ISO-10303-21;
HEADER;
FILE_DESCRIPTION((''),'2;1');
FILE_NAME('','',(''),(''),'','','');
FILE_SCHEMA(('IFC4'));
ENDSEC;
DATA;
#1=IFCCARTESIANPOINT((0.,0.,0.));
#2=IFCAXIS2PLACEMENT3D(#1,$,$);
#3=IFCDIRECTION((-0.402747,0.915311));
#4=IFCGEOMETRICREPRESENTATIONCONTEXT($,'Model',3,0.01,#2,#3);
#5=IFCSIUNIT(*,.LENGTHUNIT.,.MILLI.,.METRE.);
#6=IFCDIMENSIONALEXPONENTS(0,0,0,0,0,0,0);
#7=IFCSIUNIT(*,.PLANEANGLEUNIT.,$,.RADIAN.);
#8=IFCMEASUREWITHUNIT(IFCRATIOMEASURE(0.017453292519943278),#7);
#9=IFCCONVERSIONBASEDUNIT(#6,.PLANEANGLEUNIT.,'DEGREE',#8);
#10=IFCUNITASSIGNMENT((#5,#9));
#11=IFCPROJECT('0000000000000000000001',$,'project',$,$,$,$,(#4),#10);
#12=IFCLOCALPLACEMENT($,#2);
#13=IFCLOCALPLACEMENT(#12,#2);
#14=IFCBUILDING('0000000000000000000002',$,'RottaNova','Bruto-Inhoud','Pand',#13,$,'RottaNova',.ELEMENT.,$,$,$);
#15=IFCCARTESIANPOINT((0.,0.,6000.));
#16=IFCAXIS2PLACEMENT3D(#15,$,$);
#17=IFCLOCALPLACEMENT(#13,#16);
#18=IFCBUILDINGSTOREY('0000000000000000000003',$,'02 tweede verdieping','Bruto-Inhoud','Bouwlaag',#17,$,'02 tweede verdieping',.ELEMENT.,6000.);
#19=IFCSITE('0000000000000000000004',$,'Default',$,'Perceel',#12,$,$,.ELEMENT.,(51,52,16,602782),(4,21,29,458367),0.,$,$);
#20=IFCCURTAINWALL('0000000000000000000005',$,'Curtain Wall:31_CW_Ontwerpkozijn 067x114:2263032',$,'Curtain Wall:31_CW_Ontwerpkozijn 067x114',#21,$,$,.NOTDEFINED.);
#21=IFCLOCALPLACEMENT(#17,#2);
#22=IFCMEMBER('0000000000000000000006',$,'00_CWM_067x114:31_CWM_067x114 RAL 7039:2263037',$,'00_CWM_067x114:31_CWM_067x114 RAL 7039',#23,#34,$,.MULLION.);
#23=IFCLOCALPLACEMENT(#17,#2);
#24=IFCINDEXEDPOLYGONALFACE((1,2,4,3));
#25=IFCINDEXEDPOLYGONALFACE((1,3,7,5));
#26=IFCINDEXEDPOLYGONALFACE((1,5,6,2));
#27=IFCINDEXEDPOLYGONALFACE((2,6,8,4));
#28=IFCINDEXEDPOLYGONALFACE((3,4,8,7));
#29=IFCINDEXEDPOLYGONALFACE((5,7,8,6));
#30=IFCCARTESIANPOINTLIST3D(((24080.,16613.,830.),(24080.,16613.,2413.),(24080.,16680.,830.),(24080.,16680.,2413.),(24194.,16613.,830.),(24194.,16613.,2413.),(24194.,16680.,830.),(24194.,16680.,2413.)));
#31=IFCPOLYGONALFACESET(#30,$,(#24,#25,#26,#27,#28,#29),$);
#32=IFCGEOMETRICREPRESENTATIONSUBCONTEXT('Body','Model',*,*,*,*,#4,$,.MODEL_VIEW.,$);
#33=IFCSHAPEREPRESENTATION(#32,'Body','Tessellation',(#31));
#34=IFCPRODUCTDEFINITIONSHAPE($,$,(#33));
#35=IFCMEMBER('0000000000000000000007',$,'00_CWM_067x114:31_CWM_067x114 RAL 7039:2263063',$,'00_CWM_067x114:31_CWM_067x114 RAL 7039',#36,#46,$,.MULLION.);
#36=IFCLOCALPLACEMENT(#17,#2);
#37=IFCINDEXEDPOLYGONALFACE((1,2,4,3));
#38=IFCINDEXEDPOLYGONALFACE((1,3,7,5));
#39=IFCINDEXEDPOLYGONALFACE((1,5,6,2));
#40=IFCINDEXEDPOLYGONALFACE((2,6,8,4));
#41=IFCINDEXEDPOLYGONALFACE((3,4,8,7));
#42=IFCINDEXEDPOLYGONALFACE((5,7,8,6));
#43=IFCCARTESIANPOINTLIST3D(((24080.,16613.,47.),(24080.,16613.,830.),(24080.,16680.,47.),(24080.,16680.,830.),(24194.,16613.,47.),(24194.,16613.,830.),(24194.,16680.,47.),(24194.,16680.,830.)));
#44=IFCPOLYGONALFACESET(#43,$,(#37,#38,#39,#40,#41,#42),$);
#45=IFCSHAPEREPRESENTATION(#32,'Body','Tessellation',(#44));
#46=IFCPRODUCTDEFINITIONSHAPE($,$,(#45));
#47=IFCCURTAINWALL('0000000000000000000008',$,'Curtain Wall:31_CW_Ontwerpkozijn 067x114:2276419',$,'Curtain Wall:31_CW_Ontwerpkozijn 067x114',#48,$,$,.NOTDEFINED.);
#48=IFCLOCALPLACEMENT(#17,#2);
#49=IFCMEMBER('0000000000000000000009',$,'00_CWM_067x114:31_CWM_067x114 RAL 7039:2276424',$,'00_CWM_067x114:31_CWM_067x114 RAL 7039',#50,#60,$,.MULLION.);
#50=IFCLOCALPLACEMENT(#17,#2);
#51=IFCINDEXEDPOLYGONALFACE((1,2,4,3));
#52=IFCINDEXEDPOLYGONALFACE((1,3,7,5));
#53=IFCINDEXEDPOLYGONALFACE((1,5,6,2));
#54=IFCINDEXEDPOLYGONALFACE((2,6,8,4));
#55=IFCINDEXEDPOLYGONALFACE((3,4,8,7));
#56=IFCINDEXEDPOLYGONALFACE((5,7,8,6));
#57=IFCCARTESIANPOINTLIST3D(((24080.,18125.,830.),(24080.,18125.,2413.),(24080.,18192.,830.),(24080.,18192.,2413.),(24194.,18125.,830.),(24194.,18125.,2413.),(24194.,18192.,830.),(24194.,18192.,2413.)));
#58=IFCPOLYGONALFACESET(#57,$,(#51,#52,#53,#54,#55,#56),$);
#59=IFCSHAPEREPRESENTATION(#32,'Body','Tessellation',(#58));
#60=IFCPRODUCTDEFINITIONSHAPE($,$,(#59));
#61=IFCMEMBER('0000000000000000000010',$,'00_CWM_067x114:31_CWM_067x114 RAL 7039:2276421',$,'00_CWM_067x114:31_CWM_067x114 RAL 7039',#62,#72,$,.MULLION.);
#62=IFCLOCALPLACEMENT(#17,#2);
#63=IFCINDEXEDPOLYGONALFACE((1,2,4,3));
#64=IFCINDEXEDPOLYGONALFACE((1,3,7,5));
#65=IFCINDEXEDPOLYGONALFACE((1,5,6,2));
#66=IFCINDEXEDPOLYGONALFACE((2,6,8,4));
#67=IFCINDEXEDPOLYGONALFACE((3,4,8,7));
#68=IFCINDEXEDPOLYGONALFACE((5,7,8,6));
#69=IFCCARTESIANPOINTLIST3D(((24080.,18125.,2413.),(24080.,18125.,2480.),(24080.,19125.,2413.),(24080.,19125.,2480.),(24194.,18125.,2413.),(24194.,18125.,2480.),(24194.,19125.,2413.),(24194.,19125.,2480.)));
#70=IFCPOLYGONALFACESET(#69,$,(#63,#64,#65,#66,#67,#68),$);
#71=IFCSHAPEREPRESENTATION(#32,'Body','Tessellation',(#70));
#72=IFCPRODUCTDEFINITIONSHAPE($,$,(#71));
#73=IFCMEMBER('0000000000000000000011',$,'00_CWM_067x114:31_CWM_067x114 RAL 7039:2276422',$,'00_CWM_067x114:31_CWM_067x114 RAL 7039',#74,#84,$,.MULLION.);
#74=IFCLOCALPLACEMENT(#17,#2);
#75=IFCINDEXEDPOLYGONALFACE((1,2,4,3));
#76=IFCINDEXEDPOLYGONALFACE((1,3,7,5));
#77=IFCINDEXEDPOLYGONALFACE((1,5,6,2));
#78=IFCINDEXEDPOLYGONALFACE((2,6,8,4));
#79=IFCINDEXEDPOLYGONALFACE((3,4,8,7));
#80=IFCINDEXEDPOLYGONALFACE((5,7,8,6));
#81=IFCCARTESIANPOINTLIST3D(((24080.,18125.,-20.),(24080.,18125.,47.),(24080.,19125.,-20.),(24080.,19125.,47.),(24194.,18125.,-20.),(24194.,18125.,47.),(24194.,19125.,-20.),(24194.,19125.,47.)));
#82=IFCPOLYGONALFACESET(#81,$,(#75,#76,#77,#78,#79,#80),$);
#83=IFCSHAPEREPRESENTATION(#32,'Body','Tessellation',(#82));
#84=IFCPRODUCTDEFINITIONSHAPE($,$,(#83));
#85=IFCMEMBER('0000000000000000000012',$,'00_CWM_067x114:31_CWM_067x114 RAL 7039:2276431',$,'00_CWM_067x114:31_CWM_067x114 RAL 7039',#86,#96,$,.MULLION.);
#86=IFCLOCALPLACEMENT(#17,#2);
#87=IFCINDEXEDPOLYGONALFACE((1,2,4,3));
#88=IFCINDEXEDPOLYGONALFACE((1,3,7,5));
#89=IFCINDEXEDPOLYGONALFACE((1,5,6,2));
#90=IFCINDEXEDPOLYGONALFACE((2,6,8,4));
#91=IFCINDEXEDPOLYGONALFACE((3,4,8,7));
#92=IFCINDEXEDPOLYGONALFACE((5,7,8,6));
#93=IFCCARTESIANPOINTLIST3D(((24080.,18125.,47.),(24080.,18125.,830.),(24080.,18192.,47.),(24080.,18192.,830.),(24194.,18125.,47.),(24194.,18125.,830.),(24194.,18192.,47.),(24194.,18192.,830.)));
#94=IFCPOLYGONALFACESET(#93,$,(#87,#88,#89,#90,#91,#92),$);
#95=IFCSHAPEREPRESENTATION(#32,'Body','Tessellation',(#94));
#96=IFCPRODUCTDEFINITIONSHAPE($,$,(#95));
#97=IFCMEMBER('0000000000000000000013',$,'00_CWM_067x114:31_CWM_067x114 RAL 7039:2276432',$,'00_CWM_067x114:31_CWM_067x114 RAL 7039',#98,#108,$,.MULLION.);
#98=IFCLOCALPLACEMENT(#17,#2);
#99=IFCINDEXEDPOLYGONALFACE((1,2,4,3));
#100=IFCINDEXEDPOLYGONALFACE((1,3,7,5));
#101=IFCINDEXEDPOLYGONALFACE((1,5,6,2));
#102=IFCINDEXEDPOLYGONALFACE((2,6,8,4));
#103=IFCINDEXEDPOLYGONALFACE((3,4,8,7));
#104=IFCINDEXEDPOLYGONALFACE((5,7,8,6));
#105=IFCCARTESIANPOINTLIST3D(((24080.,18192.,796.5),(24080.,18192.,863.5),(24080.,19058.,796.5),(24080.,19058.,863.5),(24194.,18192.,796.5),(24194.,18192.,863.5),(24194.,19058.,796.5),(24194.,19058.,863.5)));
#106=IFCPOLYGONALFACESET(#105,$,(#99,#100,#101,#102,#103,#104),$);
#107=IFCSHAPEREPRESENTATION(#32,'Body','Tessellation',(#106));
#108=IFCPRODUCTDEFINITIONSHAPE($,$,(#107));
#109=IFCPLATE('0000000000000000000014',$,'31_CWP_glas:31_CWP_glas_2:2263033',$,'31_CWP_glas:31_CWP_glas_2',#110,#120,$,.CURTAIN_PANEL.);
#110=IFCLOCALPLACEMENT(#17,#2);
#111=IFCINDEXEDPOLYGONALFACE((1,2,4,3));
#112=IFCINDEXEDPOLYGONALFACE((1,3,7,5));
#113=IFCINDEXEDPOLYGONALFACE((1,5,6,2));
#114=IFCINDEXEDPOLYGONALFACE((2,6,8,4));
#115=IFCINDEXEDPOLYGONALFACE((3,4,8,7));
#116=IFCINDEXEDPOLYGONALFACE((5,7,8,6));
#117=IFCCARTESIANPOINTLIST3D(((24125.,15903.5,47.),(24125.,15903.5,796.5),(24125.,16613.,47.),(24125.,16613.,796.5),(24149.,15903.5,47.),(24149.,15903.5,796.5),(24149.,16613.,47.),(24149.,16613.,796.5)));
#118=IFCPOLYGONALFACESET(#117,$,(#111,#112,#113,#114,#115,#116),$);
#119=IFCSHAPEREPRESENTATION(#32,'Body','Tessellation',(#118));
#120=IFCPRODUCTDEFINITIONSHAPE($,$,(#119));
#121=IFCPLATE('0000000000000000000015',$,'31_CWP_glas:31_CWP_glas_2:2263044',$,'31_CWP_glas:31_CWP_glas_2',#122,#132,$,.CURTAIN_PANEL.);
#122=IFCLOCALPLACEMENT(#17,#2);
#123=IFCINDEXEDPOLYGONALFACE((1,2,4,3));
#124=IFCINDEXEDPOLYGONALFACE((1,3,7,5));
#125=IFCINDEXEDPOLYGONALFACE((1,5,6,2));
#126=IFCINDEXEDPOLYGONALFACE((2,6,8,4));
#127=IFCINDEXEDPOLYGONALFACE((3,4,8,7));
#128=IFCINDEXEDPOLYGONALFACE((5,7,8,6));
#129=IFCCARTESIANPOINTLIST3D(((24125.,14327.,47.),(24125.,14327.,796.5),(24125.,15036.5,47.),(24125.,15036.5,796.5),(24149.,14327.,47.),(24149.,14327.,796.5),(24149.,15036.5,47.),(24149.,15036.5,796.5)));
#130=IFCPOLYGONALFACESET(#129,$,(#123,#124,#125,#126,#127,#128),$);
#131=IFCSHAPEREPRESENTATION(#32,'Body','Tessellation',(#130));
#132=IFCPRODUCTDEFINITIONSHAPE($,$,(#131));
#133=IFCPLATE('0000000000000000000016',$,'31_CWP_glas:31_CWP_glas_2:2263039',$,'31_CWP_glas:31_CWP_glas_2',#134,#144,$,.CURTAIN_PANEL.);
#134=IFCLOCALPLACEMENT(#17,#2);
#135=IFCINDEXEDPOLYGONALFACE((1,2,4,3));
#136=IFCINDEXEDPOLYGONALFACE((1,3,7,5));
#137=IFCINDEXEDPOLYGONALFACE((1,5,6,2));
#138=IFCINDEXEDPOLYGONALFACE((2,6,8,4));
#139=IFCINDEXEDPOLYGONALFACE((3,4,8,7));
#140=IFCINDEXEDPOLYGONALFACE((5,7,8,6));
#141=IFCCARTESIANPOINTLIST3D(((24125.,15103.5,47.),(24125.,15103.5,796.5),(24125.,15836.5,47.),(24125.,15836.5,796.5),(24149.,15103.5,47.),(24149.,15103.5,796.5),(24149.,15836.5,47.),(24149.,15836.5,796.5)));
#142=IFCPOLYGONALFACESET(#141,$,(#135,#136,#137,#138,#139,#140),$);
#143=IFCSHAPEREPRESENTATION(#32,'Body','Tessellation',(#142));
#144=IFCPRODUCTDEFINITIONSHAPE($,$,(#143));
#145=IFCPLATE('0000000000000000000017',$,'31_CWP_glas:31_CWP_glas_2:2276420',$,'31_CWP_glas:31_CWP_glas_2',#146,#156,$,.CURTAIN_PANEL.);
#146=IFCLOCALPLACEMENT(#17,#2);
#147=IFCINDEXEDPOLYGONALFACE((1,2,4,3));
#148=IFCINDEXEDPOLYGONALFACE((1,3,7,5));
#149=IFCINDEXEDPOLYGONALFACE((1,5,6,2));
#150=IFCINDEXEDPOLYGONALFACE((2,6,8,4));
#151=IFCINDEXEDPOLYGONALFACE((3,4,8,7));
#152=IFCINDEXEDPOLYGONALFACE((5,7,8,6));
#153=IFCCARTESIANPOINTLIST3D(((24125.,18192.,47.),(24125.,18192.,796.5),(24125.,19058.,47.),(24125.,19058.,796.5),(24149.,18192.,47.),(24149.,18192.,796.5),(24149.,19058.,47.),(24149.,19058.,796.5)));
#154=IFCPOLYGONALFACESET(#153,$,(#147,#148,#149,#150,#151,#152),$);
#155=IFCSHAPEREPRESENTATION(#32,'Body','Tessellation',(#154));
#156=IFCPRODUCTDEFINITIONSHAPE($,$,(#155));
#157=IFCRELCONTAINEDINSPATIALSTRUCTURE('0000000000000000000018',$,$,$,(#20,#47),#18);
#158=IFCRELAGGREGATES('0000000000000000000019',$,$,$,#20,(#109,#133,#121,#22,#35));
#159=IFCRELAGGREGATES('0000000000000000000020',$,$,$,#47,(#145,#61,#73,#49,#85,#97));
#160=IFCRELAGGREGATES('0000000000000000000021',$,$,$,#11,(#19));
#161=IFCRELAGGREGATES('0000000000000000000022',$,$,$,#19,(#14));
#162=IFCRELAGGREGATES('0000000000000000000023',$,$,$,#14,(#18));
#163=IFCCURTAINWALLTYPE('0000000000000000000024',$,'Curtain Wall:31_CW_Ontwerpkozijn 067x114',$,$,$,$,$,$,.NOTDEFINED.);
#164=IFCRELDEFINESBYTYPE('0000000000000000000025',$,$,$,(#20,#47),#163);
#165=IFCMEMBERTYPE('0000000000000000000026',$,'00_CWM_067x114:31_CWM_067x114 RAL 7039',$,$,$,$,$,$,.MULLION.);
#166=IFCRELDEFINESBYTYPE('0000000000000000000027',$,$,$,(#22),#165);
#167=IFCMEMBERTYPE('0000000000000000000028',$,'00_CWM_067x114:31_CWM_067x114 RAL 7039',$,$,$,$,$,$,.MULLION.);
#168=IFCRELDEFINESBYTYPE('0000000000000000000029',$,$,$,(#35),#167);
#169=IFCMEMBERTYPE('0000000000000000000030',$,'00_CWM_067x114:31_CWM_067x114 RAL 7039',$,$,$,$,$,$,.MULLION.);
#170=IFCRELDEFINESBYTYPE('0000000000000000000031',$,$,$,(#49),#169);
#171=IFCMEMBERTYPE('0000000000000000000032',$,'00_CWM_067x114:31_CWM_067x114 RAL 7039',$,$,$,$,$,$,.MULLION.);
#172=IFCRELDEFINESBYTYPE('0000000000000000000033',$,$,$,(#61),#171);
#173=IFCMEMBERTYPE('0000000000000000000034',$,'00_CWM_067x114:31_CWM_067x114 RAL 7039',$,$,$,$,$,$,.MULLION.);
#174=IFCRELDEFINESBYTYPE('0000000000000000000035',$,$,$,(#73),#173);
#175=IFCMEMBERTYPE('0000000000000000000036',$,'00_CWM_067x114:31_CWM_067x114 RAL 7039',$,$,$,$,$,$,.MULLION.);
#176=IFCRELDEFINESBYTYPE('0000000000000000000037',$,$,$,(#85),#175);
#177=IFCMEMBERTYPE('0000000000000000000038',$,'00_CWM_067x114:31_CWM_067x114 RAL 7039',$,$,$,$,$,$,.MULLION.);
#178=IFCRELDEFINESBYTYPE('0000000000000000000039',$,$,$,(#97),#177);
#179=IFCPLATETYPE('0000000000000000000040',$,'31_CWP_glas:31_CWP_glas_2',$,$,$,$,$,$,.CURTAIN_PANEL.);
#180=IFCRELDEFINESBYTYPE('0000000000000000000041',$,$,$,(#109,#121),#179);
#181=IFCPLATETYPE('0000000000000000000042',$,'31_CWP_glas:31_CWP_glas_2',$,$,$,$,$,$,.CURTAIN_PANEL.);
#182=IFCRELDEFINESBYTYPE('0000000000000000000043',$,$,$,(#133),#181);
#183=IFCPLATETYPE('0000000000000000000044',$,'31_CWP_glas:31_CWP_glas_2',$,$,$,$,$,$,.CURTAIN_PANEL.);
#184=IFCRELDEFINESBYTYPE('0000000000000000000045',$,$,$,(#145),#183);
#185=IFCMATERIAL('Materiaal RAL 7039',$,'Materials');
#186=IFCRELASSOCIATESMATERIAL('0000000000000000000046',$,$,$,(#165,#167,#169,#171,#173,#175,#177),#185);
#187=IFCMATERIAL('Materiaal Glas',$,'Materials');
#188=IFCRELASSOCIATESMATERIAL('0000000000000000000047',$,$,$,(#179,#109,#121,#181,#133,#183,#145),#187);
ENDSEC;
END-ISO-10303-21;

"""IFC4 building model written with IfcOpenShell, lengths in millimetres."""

from ifc_helpers import new_model, entity, si_unit, converted_unit, direction, frame, frame_2d, origin, origin_2d_with_axis, place, context, subcontext, project, spatial, rectangle, extrude, source, transform, mapped, material, material_profile, profile_set, type_object, type_shapes, element, aggregate, save


model = new_model("IFC4")

# Units and contexts
model_context = context("Model", 3, precision=0.01, world=origin(), true_north=direction((-0.402747, 0.915311)))
body_context = subcontext(model_context, "Body", "Model", "MODEL_VIEW")
ifc_project = project(units=[si_unit("LENGTHUNIT", "METRE", prefix="MILLI"), converted_unit("PLANEANGLEUNIT", "DEGREE", entity("IfcRatioMeasure", 0.017453292519943278), si_unit("PLANEANGLEUNIT", "RADIAN"), dimensions=[0, 0, 0, 0, 0, 0, 0])], contexts=[model_context])

# Site, building, storey
site_placement = place(None, origin())
site = spatial("IfcSite", under=ifc_project, at=site_placement, Name="Default", ObjectType="Perceel", CompositionType="ELEMENT", RefLatitude=(51, 52, 16, 602782), RefLongitude=(4, 21, 29, 458367), RefElevation=0.0)
building_placement = place(site_placement, origin())
building = spatial("IfcBuilding", under=site, at=building_placement, Name="RottaNova", Description="Bruto-Inhoud", ObjectType="Pand", LongName="RottaNova", CompositionType="ELEMENT")
storey_placement = place(building_placement, frame((0.0, 0.0, 6000.0)))
storey = spatial("IfcBuildingStorey", under=building, at=storey_placement, Name="02 tweede verdieping", Description="Bruto-Inhoud", ObjectType="Bouwlaag", LongName="02 tweede verdieping", CompositionType="ELEMENT", Elevation=6000.0)

# Curtain walls, members
curtain_wall_type = type_object("IfcCurtainWallType", Name="Curtain Wall:31_CW_Ontwerpkozijn 067x114", PredefinedType="NOTDEFINED")
curtain_wall_1_placement = place(storey_placement, frame((0.0, 0.0, -6000.0)))
curtain_wall_1 = element("IfcCurtainWall", 1, at=curtain_wall_1_placement, inside=storey, type_object=curtain_wall_type, Name="Curtain Wall:31_CW_Ontwerpkozijn 067x114:2263032", ObjectType="Curtain Wall:31_CW_Ontwerpkozijn 067x114", PredefinedType="NOTDEFINED")
ifc_material_1 = material(Name="Materiaal RAL 7039", Category="Materials")
ifc_material_profile = material_profile(ifc_material_1, rectangle(XDim=114.0, YDim=67.0, at=origin_2d_with_axis()), Name="31_CWM_067x114 RAL 7039")
ifc_profile_set = profile_set([ifc_material_profile], Name="31_CWM_067x114 RAL 7039")
member_type_1 = type_object("IfcMemberType", Name="00_CWM_067x114:31_CWM_067x114 RAL 7039", PredefinedType="MULLION", material=ifc_profile_set)
shared_shape_1 = source(origin(), body_context, "Body", "SweptSolid", [
    extrude(rectangle(XDim=114.0, YDim=67.0, at=frame_2d((0.0, 0.0), x_axis=(1.0, 0.0))), frame((-33.5, -57.0, -1583.0), z_axis=(0.0, 0.0, 1.0), x_axis=(0.0, -1.0, 0.0)), (0.0, 0.0, 1.0), 1583.0),
])
type_shapes(member_type_1, [shared_shape_1])
member_1_placement = place(curtain_wall_1_placement, frame((24080.0, 16680.0, 8413.0), z_axis=(0.0, 0.0, 1.0), x_axis=(0.0, 1.0, 0.0)))
member_1 = element("IfcMember", 2, at=member_1_placement, type_object=member_type_1, Name="00_CWM_067x114:31_CWM_067x114 RAL 7039:2263037", ObjectType="00_CWM_067x114:31_CWM_067x114 RAL 7039", PredefinedType="MULLION", context=body_context, shape_type="MappedRepresentation", body=[
    mapped(shared_shape_1, transform((0.0, 0.0, 0.0), scale=1.0)),
])
member_type_2 = type_object("IfcMemberType", Name="00_CWM_067x114:31_CWM_067x114 RAL 7039", PredefinedType="MULLION", material=ifc_profile_set)
shared_shape_2 = source(origin(), body_context, "Body", "SweptSolid", [
    extrude(rectangle(XDim=114.0, YDim=67.0, at=frame_2d((0.0, 0.0), x_axis=(1.0, 0.0))), frame((-33.5, -57.0, -783.0), z_axis=(0.0, 0.0, 1.0), x_axis=(0.0, -1.0, 0.0)), (0.0, 0.0, 1.0), 783.0),
])
type_shapes(member_type_2, [shared_shape_2])
member_2_placement = place(curtain_wall_1_placement, frame((24080.0, 16680.0, 6830.0), z_axis=(0.0, 0.0, 1.0), x_axis=(0.0, 1.0, 0.0)))
member_2 = element("IfcMember", 3, at=member_2_placement, type_object=member_type_2, Name="00_CWM_067x114:31_CWM_067x114 RAL 7039:2263063", ObjectType="00_CWM_067x114:31_CWM_067x114 RAL 7039", PredefinedType="MULLION", context=body_context, shape_type="MappedRepresentation", body=[
    mapped(shared_shape_2, transform((0.0, 0.0, 0.0), scale=1.0)),
])
curtain_wall_2_placement = place(storey_placement, frame((0.0, 0.0, -6000.0)))
curtain_wall_2 = element("IfcCurtainWall", 4, at=curtain_wall_2_placement, inside=storey, type_object=curtain_wall_type, Name="Curtain Wall:31_CW_Ontwerpkozijn 067x114:2276419", ObjectType="Curtain Wall:31_CW_Ontwerpkozijn 067x114", PredefinedType="NOTDEFINED")
member_type_3 = type_object("IfcMemberType", Name="00_CWM_067x114:31_CWM_067x114 RAL 7039", PredefinedType="MULLION", material=ifc_profile_set)
shared_shape_3 = source(origin(), body_context, "Body", "SweptSolid", [
    extrude(rectangle(XDim=114.0, YDim=67.0, at=origin_2d_with_axis()), frame((-33.5, 57.0, -1583.0), z_axis=(0.0, 0.0, 1.0), x_axis=(0.0, -1.0, 0.0)), (0.0, 0.0, 1.0), 1583.0),
])
type_shapes(member_type_3, [shared_shape_3])
member_3_placement = place(curtain_wall_2_placement, frame((24080.0, 18125.0, 8413.0), z_axis=(0.0, 0.0, 1.0), x_axis=(0.0, -1.0, 0.0)))
member_3 = element("IfcMember", 5, at=member_3_placement, type_object=member_type_3, Name="00_CWM_067x114:31_CWM_067x114 RAL 7039:2276424", ObjectType="00_CWM_067x114:31_CWM_067x114 RAL 7039", PredefinedType="MULLION", context=body_context, shape_type="MappedRepresentation", body=[
    mapped(shared_shape_3, transform((0.0, 0.0, 0.0), scale=1.0)),
])
member_type_4 = type_object("IfcMemberType", Name="00_CWM_067x114:31_CWM_067x114 RAL 7039", PredefinedType="MULLION", material=ifc_profile_set)
shared_shape_4 = source(origin(), body_context, "Body", "SweptSolid", [
    extrude(rectangle(XDim=114.0, YDim=67.0, at=origin_2d_with_axis()), frame((-33.5, 57.0, -1000.0), z_axis=(0.0, 0.0, 1.0), x_axis=(0.0, -1.0, 0.0)), (0.0, 0.0, 1.0), 1000.0),
])
type_shapes(member_type_4, [shared_shape_4])
member_4_placement = place(curtain_wall_2_placement, frame((24080.0, 19125.0, 8480.0), z_axis=(0.0, 1.0, 0.0), x_axis=(0.0, 0.0, 1.0)))
member_4 = element("IfcMember", 6, at=member_4_placement, type_object=member_type_4, Name="00_CWM_067x114:31_CWM_067x114 RAL 7039:2276421", ObjectType="00_CWM_067x114:31_CWM_067x114 RAL 7039", PredefinedType="MULLION", context=body_context, shape_type="MappedRepresentation", body=[
    mapped(shared_shape_4, transform((0.0, 0.0, 0.0), scale=1.0)),
])
member_type_5 = type_object("IfcMemberType", Name="00_CWM_067x114:31_CWM_067x114 RAL 7039", PredefinedType="MULLION", material=ifc_profile_set)
shared_shape_5 = source(origin(), body_context, "Body", "SweptSolid", [
    extrude(rectangle(XDim=114.0, YDim=67.0, at=origin_2d_with_axis()), frame((-33.5, 57.0, -1000.0), z_axis=(0.0, 0.0, 1.0), x_axis=(0.0, -1.0, 0.0)), (0.0, 0.0, 1.0), 1000.0),
])
type_shapes(member_type_5, [shared_shape_5])
member_5_placement = place(curtain_wall_2_placement, frame((24080.0, 18125.0, 5980.0), z_axis=(0.0, -1.0, 0.0), x_axis=(0.0, 0.0, -1.0)))
member_5 = element("IfcMember", 7, at=member_5_placement, type_object=member_type_5, Name="00_CWM_067x114:31_CWM_067x114 RAL 7039:2276422", ObjectType="00_CWM_067x114:31_CWM_067x114 RAL 7039", PredefinedType="MULLION", context=body_context, shape_type="MappedRepresentation", body=[
    mapped(shared_shape_5, transform((0.0, 0.0, 0.0), scale=1.0)),
])
member_type_6 = type_object("IfcMemberType", Name="00_CWM_067x114:31_CWM_067x114 RAL 7039", PredefinedType="MULLION", material=ifc_profile_set)
shared_shape_6 = source(origin(), body_context, "Body", "SweptSolid", [
    extrude(rectangle(XDim=114.0, YDim=67.0, at=origin_2d_with_axis()), frame((-33.5, 57.0, -783.0), z_axis=(0.0, 0.0, 1.0), x_axis=(0.0, -1.0, 0.0)), (0.0, 0.0, 1.0), 783.0),
])
type_shapes(member_type_6, [shared_shape_6])
member_6_placement = place(curtain_wall_2_placement, frame((24080.0, 18125.0, 6830.0), z_axis=(0.0, 0.0, 1.0), x_axis=(0.0, -1.0, 0.0)))
member_6 = element("IfcMember", 8, at=member_6_placement, type_object=member_type_6, Name="00_CWM_067x114:31_CWM_067x114 RAL 7039:2276431", ObjectType="00_CWM_067x114:31_CWM_067x114 RAL 7039", PredefinedType="MULLION", context=body_context, shape_type="MappedRepresentation", body=[
    mapped(shared_shape_6, transform((0.0, 0.0, 0.0), scale=1.0)),
])
member_type_7 = type_object("IfcMemberType", Name="00_CWM_067x114:31_CWM_067x114 RAL 7039", PredefinedType="MULLION", material=ifc_profile_set)
shared_shape_7 = source(origin(), body_context, "Body", "SweptSolid", [
    extrude(rectangle(XDim=114.0, YDim=67.0, at=origin_2d_with_axis()), frame((0.0, 57.0, -866.0), z_axis=(0.0, 0.0, 1.0), x_axis=(0.0, -1.0, 0.0)), (0.0, 0.0, 1.0), 866.0),
])
type_shapes(member_type_7, [shared_shape_7])
member_7_placement = place(curtain_wall_2_placement, frame((24080.0, 19058.0, 6830.0), z_axis=(0.0, 1.0, 0.0), x_axis=(0.0, 0.0, 1.0)))
member_7 = element("IfcMember", 9, at=member_7_placement, type_object=member_type_7, Name="00_CWM_067x114:31_CWM_067x114 RAL 7039:2276432", ObjectType="00_CWM_067x114:31_CWM_067x114 RAL 7039", PredefinedType="MULLION", context=body_context, shape_type="MappedRepresentation", body=[
    mapped(shared_shape_7, transform((0.0, 0.0, 0.0), scale=1.0)),
])

# Plates
ifc_material_2 = material(Name="Materiaal Glas", Category="Materials")
plate_type_1 = type_object("IfcPlateType", Name="31_CWP_glas:31_CWP_glas_2", PredefinedType="CURTAIN_PANEL", material=ifc_material_2)
shared_shape_8 = source(origin(), body_context, "Body", "SweptSolid", [
    extrude(rectangle(XDim=24.0, YDim=709.5, at=frame_2d((0.0, 0.0), x_axis=(1.0, 0.0))), frame((354.8, 12.0, 0.0), z_axis=(0.0, 0.0, 1.0), x_axis=(0.0, 1.0, 0.0)), (0.0, 0.0, 1.0), 749.5),
])
type_shapes(plate_type_1, [shared_shape_8])
plate_1_placement = place(curtain_wall_1_placement, frame((24125.0, 16613.0, 6047.0), z_axis=(0.0, 0.0, 1.0), x_axis=(0.0, -1.0, 0.0)))
plate_1 = element("IfcPlate", 10, at=plate_1_placement, type_object=plate_type_1, material=ifc_material_2, Name="31_CWP_glas:31_CWP_glas_2:2263033", ObjectType="31_CWP_glas:31_CWP_glas_2", PredefinedType="CURTAIN_PANEL", context=body_context, shape_type="MappedRepresentation", body=[
    mapped(shared_shape_8, transform((0.0, 0.0, 0.0), scale=1.0)),
])
plate_2_placement = place(curtain_wall_1_placement, frame((24125.0, 15036.5, 6047.0), z_axis=(0.0, 0.0, 1.0), x_axis=(0.0, -1.0, 0.0)))
plate_2 = element("IfcPlate", 11, at=plate_2_placement, type_object=plate_type_1, material=ifc_material_2, Name="31_CWP_glas:31_CWP_glas_2:2263044", ObjectType="31_CWP_glas:31_CWP_glas_2", PredefinedType="CURTAIN_PANEL", context=body_context, shape_type="MappedRepresentation", body=[
    mapped(shared_shape_8, transform((0.0, 0.0, 0.0), scale=1.0)),
])
plate_type_2 = type_object("IfcPlateType", Name="31_CWP_glas:31_CWP_glas_2", PredefinedType="CURTAIN_PANEL", material=ifc_material_2)
shared_shape_9 = source(origin(), body_context, "Body", "SweptSolid", [
    extrude(rectangle(XDim=24.0, YDim=733.0, at=frame_2d((0.0, 0.0), x_axis=(1.0, 0.0))), frame((366.5, 12.0, 0.0), z_axis=(0.0, 0.0, 1.0), x_axis=(0.0, 1.0, 0.0)), (0.0, 0.0, 1.0), 749.5),
])
type_shapes(plate_type_2, [shared_shape_9])
plate_3_placement = place(curtain_wall_1_placement, frame((24125.0, 15836.5, 6047.0), z_axis=(0.0, 0.0, 1.0), x_axis=(0.0, -1.0, 0.0)))
plate_3 = element("IfcPlate", 12, at=plate_3_placement, type_object=plate_type_2, material=ifc_material_2, Name="31_CWP_glas:31_CWP_glas_2:2263039", ObjectType="31_CWP_glas:31_CWP_glas_2", PredefinedType="CURTAIN_PANEL", context=body_context, shape_type="MappedRepresentation", body=[
    mapped(shared_shape_9, transform((0.0, 0.0, 0.0), scale=1.0)),
])
aggregate(curtain_wall_1, [plate_1, plate_3, plate_2, member_1, member_2])
plate_type_3 = type_object("IfcPlateType", Name="31_CWP_glas:31_CWP_glas_2", PredefinedType="CURTAIN_PANEL", material=ifc_material_2)
shared_shape_10 = source(origin(), body_context, "Body", "SweptSolid", [
    extrude(rectangle(XDim=24.0, YDim=866.0, at=frame_2d((0.0, 0.0), x_axis=(1.0, 0.0))), frame((433.0, 12.0, 0.0), z_axis=(0.0, 0.0, 1.0), x_axis=(0.0, 1.0, 0.0)), (0.0, 0.0, 1.0), 749.5),
])
type_shapes(plate_type_3, [shared_shape_10])
plate_4_placement = place(curtain_wall_2_placement, frame((24149.0, 18192.0, 6047.0), z_axis=(0.0, 0.0, 1.0), x_axis=(0.0, 1.0, 0.0)))
plate_4 = element("IfcPlate", 13, at=plate_4_placement, type_object=plate_type_3, material=ifc_material_2, Name="31_CWP_glas:31_CWP_glas_2:2276420", ObjectType="31_CWP_glas:31_CWP_glas_2", PredefinedType="CURTAIN_PANEL", context=body_context, shape_type="MappedRepresentation", body=[
    mapped(shared_shape_10, transform((0.0, 0.0, 0.0), scale=1.0)),
])

aggregate(curtain_wall_2, [plate_4, member_4, member_5, member_3, member_6, member_7])

save(model, "model.ifc")
